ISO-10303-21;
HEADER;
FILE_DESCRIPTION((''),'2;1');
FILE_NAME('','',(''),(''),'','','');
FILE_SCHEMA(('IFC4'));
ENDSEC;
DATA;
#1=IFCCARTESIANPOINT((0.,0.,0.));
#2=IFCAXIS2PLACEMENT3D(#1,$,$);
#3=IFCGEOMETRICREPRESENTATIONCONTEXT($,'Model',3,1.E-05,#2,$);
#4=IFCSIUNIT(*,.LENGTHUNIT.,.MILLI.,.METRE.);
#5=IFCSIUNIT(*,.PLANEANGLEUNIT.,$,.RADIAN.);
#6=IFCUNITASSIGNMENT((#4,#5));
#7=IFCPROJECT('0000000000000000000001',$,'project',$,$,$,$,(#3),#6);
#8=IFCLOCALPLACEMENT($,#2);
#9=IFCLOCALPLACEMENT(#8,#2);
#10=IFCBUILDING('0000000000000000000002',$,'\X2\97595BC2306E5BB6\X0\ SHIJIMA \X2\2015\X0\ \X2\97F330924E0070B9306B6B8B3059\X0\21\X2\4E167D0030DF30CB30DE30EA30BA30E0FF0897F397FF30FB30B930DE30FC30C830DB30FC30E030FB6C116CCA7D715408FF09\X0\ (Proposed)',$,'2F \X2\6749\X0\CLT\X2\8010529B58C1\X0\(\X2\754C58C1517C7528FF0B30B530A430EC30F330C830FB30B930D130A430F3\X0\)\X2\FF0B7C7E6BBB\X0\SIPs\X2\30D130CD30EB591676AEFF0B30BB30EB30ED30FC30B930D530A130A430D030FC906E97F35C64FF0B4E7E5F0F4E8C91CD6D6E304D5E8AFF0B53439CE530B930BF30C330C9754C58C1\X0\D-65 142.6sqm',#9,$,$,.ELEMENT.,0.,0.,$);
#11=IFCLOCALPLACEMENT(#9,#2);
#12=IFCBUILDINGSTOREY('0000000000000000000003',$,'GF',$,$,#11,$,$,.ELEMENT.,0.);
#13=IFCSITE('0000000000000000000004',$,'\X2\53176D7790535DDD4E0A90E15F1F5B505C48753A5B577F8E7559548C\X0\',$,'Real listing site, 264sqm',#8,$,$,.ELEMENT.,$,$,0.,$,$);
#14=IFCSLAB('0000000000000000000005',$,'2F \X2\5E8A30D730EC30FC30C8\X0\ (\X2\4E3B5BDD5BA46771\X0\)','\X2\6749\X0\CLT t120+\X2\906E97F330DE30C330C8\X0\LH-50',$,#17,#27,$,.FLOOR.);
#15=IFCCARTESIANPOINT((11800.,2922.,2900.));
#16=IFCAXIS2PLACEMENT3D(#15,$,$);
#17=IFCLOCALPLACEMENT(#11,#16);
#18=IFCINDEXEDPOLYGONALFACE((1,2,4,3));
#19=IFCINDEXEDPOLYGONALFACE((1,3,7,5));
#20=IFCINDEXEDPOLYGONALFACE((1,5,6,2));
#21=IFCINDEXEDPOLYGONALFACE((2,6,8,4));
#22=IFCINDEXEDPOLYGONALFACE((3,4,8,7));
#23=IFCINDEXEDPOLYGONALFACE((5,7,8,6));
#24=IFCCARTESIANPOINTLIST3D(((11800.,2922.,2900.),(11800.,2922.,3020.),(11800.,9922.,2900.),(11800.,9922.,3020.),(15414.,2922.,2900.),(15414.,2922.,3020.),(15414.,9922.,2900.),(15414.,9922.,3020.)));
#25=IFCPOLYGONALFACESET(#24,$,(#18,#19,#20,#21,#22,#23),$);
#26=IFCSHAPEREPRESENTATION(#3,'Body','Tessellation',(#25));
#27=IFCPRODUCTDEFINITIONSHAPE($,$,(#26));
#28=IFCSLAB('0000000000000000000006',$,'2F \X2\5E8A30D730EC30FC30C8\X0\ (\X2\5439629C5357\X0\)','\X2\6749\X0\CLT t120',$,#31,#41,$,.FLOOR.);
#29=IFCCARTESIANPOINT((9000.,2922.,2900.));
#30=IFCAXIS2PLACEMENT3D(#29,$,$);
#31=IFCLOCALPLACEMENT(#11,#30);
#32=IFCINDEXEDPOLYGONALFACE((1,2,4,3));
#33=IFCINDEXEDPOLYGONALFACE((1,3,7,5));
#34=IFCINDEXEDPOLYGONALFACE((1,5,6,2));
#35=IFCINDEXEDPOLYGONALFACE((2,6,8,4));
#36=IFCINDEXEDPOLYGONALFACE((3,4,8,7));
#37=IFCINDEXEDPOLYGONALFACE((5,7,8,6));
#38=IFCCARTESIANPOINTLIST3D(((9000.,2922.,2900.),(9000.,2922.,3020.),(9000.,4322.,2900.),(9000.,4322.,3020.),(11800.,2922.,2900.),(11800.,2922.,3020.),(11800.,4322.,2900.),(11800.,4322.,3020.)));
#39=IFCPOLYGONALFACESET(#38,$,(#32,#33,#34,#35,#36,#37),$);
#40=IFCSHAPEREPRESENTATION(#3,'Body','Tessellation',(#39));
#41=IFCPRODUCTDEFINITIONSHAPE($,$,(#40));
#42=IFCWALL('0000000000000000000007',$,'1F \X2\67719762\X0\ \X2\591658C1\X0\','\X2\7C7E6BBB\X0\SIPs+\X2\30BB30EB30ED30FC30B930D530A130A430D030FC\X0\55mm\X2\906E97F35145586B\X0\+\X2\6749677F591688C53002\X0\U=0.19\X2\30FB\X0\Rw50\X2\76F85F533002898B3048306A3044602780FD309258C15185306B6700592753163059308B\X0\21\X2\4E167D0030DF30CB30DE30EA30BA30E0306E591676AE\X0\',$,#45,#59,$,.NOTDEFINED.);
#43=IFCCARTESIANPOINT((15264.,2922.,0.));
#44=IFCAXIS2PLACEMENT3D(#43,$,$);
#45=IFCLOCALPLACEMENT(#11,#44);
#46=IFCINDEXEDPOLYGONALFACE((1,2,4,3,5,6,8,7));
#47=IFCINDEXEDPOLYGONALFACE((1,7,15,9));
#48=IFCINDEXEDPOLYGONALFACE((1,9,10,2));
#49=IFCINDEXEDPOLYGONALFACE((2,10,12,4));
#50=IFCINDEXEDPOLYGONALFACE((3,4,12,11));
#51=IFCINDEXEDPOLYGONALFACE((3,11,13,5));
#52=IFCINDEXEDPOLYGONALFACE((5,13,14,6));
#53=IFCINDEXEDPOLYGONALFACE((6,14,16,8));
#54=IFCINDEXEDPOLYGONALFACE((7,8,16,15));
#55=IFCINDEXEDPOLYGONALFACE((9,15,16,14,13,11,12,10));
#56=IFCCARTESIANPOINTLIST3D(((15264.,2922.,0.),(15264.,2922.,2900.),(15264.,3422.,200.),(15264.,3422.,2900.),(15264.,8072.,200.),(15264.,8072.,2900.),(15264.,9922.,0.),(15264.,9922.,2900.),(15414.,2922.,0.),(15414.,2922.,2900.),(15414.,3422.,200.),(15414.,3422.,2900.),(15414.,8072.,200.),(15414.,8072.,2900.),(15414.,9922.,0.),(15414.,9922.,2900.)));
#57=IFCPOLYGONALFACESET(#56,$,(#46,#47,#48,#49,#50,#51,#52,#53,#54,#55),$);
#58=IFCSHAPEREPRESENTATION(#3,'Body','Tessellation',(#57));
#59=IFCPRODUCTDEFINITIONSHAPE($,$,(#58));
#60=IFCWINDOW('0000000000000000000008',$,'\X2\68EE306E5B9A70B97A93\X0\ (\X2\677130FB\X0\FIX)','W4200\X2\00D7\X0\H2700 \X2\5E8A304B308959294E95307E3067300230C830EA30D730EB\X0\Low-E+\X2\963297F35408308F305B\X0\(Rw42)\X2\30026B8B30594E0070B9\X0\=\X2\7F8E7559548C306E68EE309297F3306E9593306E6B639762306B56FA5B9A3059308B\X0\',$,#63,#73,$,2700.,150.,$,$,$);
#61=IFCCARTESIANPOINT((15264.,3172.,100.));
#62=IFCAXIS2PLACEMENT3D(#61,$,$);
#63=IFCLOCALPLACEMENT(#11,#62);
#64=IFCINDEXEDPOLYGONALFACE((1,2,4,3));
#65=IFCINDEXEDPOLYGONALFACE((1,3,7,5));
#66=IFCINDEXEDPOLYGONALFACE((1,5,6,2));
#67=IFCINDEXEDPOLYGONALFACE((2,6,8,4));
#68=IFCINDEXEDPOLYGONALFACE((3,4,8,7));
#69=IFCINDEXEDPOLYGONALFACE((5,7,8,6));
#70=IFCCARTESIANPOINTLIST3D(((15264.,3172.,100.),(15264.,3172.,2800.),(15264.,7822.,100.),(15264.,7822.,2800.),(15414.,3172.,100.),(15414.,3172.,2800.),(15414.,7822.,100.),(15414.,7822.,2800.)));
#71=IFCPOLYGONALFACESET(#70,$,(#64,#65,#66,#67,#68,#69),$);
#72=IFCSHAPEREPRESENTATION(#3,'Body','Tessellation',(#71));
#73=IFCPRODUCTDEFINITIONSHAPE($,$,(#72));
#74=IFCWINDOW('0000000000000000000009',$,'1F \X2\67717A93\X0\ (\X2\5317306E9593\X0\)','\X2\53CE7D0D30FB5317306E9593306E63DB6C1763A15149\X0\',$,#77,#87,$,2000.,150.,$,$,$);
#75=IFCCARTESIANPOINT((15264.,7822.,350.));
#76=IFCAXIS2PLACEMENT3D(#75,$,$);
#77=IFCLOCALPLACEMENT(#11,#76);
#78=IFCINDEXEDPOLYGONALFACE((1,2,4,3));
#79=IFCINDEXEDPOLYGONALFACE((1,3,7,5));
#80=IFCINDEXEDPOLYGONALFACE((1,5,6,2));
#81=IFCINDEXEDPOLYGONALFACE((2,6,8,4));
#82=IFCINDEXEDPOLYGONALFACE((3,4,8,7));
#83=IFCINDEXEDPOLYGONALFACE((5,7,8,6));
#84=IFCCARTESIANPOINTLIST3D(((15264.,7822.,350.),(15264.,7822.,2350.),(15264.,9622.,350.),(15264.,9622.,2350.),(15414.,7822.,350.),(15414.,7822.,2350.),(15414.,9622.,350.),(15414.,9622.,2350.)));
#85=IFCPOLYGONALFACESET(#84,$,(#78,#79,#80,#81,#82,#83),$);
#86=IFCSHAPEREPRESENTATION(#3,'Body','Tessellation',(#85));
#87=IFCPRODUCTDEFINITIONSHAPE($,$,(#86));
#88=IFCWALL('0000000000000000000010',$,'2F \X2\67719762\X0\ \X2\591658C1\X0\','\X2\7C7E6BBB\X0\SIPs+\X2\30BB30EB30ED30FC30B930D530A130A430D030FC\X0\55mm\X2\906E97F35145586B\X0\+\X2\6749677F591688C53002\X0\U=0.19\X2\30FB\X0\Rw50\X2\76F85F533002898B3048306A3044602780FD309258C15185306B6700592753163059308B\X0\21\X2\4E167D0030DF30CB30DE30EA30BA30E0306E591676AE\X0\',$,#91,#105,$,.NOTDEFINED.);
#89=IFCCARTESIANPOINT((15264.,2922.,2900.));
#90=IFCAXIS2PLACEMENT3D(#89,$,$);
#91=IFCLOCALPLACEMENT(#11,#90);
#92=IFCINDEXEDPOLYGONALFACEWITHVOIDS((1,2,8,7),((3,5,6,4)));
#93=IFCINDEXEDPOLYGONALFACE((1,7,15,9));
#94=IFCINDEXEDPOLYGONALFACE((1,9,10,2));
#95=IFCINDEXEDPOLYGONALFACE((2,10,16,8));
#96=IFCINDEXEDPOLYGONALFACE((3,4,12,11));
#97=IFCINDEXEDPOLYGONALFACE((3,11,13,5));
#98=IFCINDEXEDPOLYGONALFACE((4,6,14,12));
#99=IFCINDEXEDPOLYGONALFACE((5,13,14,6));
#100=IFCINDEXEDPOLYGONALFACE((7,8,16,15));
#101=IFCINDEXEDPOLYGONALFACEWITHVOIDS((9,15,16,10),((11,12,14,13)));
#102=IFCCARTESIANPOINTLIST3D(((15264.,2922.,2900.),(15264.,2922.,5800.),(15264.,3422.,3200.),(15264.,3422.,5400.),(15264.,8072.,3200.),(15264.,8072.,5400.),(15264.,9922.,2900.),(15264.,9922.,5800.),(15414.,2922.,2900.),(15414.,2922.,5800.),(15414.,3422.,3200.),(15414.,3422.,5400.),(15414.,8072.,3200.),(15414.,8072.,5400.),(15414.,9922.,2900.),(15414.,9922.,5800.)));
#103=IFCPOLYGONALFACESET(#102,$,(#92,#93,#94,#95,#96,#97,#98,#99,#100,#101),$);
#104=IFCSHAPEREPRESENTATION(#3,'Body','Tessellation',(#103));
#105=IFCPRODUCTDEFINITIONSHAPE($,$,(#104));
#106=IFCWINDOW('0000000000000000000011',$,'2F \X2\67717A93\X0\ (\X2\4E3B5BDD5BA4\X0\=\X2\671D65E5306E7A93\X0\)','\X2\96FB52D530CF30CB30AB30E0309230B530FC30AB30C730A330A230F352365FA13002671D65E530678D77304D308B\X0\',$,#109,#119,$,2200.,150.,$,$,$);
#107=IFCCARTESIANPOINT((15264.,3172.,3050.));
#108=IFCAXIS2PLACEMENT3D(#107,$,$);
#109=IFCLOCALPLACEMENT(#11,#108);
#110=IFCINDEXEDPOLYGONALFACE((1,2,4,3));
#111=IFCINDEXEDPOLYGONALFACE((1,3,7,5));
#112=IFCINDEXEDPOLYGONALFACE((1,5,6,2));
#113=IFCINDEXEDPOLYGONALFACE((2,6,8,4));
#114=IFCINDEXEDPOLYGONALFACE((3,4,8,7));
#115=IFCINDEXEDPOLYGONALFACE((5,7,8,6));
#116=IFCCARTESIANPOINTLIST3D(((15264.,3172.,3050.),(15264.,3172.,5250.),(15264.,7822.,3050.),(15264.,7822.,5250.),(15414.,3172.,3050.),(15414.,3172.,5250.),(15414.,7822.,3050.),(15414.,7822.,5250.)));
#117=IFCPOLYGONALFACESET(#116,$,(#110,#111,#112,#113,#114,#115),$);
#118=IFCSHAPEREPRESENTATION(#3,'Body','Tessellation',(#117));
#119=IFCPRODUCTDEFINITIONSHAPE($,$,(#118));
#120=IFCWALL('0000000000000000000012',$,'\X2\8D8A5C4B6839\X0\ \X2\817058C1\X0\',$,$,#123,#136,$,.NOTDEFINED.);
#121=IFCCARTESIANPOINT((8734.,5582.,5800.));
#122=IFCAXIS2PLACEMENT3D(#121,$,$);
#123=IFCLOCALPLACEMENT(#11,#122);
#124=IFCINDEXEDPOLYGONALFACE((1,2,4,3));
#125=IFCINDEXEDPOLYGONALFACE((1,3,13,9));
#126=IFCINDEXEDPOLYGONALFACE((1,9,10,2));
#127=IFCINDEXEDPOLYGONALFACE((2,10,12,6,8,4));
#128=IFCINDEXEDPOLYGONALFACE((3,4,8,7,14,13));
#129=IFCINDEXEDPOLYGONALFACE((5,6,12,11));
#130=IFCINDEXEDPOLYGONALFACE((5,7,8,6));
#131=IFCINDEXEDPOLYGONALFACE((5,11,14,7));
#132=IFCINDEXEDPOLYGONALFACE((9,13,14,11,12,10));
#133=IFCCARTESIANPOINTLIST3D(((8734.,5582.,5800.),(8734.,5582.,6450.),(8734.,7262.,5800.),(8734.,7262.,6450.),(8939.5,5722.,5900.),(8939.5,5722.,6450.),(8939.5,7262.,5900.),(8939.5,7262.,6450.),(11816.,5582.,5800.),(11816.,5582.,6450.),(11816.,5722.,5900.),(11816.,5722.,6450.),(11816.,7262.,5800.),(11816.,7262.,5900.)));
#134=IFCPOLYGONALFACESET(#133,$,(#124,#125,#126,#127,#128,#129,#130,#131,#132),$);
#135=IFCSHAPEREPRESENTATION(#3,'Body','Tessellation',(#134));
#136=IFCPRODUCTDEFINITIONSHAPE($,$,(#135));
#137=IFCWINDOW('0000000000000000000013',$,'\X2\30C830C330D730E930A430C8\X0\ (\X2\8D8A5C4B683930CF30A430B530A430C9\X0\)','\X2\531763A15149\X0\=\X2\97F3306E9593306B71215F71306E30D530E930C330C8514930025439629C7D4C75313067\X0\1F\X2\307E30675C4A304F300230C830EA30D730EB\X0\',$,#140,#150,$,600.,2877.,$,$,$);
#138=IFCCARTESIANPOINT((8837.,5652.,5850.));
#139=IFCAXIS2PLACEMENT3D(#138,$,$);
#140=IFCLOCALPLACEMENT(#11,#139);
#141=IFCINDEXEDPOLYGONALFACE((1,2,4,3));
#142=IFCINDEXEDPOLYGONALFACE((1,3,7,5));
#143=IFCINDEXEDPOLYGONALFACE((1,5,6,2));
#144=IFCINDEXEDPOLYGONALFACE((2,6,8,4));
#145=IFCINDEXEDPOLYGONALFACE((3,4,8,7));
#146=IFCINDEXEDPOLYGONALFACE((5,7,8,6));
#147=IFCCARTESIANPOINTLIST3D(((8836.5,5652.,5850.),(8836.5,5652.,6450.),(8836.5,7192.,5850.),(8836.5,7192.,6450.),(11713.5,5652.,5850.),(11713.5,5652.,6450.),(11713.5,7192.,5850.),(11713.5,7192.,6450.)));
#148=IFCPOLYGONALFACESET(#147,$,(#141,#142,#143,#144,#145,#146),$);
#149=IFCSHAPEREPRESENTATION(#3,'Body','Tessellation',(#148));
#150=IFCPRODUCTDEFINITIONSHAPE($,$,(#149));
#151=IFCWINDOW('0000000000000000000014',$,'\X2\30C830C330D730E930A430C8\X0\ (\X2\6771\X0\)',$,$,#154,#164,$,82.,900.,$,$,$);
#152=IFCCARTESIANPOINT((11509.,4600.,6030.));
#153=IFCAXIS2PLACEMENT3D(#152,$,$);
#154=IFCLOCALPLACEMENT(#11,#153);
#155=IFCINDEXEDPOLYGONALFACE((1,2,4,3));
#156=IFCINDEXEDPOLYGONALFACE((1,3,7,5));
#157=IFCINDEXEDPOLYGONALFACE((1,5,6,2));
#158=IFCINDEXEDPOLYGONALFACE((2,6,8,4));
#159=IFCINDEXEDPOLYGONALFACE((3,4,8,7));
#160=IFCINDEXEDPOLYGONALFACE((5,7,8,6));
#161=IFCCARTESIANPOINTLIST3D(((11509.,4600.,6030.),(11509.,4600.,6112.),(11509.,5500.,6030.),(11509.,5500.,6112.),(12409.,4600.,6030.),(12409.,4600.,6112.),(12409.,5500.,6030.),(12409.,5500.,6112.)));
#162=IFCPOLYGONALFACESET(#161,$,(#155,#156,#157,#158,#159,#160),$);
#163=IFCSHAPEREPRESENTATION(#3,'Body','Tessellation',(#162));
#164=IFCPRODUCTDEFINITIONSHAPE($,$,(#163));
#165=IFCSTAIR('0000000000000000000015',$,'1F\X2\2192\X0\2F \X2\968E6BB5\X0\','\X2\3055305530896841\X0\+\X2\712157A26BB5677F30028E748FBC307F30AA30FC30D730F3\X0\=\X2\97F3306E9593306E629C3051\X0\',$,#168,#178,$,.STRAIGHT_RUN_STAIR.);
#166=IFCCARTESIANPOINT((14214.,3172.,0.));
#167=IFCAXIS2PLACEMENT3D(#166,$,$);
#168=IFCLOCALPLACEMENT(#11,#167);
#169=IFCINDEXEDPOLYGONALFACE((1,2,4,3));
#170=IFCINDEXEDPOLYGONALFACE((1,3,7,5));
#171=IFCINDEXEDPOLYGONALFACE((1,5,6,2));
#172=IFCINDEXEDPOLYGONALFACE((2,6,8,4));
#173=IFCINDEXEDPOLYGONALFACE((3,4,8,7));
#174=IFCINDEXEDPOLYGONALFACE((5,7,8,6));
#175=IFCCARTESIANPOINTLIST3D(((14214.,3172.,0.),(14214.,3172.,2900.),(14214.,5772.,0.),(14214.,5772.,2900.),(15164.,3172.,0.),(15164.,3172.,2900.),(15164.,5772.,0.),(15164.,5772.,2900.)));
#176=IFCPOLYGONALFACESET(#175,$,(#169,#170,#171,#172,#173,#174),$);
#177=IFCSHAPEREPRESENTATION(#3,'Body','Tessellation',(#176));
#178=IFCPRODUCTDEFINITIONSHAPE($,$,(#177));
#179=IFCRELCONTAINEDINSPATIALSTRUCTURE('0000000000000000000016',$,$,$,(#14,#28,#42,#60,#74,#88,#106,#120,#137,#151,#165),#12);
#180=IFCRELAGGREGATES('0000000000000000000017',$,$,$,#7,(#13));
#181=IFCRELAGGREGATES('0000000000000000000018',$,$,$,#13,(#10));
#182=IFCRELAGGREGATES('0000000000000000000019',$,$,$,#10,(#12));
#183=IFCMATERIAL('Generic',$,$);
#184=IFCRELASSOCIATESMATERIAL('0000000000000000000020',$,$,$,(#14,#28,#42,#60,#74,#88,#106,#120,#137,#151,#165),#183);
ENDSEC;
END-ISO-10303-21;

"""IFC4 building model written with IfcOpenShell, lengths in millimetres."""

from ifc_helpers import new_model, si_unit, frame, frame_2d, origin, place, context, project, spatial, rectangle, extrude, material, element, fill, save


model = new_model("IFC4")

# Units and contexts
model_context = context("Model", 3, precision=1e-05, world=origin())
ifc_project = project(units=[si_unit("LENGTHUNIT", "METRE", prefix="MILLI"), si_unit("PLANEANGLEUNIT", "RADIAN")], contexts=[model_context])

# Site, building, storey
site_placement = place(None, origin())
site = spatial("IfcSite", under=ifc_project, at=site_placement, Name="北海道川上郡弟子屈町字美留和", ObjectType="Real listing site, 264sqm", CompositionType="ELEMENT", RefElevation=0.0)
building_placement = place(site_placement, origin())
building = spatial("IfcBuilding", under=site, at=building_placement, Name="静寂の家 SHIJIMA ― 音を一点に残す21世紀ミニマリズム（音響・スマートホーム・民泊統合） (Proposed)", ObjectType="2F 杉CLT耐力壁(界壁兼用＋サイレント・スパイン)＋籾殻SIPsパネル外皮＋セルロースファイバー遮音層＋乾式二重浮き床＋千鳥スタッド界壁D-65 142.6sqm", CompositionType="ELEMENT", ElevationOfRefHeight=0.0, ElevationOfTerrain=0.0)
storey_placement = place(building_placement, origin())
storey = spatial("IfcBuildingStorey", under=building, at=storey_placement, Name="GF", CompositionType="ELEMENT", Elevation=0.0)

# Slabs
ifc_material = material(Name="Generic")
slab_1_placement = place(storey_placement, frame((11800.0, 2922.0, 2900.0)))
element("IfcSlab", 1, at=slab_1_placement, inside=storey, material=ifc_material, Name="2F 床プレート (主寝室東)", Description="杉CLT t120+遮音マットLH-50", PredefinedType="FLOOR", context=model_context, shape_type="SweptSolid", body=[
    extrude(rectangle(XDim=3614.0, YDim=7000.0, at=frame_2d((1807.0, 3500.0))), frame((11800.0, 2922.0, 2900.0)), (0.0, 0.0, 1.0), 120.0),
])
slab_2_placement = place(storey_placement, frame((9000.0, 2922.0, 2900.0)))
element("IfcSlab", 2, at=slab_2_placement, inside=storey, material=ifc_material, Name="2F 床プレート (吹抜南)", Description="杉CLT t120", PredefinedType="FLOOR", context=model_context, shape_type="SweptSolid", body=[
    extrude(rectangle(XDim=2800.0, YDim=1400.0, at=frame_2d((1400.0, 700.0))), frame((9000.0, 2922.0, 2900.0)), (0.0, 0.0, 1.0), 120.0),
])

# Wall, openings, windows
wall_1_placement = place(storey_placement, frame((15264.0, 2922.0, 0.0)))
wall_1 = element("IfcWall", 3, at=wall_1_placement, inside=storey, material=ifc_material, Name="1F 東面 外壁", Description="籾殻SIPs+セルロースファイバー55mm遮音充填+杉板外装。U=0.19・Rw50相当。見えない性能を壁内に最大化する21世紀ミニマリズムの外皮", PredefinedType="NOTDEFINED", context=model_context, shape_type="SweptSolid", body=[
    extrude(rectangle(XDim=150.0, YDim=7000.0, at=frame_2d((75.0, 3500.0))), frame((15264.0, 2922.0, 0.0)), (0.0, 0.0, 1.0), 2900.0),
])
opening_1_placement = place(storey_placement, frame((15264.0, 3172.0, 100.0)))
opening_1 = element("IfcOpeningElement", 4, at=opening_1_placement, cuts=wall_1, PredefinedType="NOTDEFINED", context=model_context, shape_type="SweptSolid", body=[
    extrude(rectangle(XDim=150.0, YDim=4650.0, at=frame_2d((75.0, 2325.0))), frame((15264.0, 3172.0, 100.0)), (0.0, 0.0, 1.0), 2700.0),
])
opening_2_placement = place(storey_placement, frame((15264.0, 7822.0, 350.0)))
opening_2 = element("IfcOpeningElement", 5, at=opening_2_placement, cuts=wall_1, PredefinedType="NOTDEFINED", context=model_context, shape_type="SweptSolid", body=[
    extrude(rectangle(XDim=150.0, YDim=1800.0, at=frame_2d((75.0, 900.0))), frame((15264.0, 7822.0, 350.0)), (0.0, 0.0, 1.0), 2000.0),
])
window_1_placement = place(storey_placement, frame((15264.0, 3172.0, 100.0)))
window_1 = element("IfcWindow", 6, at=window_1_placement, inside=storey, material=ifc_material, Name="森の定点窓 (東・FIX)", Description="W4200×H2700 床から天井まで。トリプルLow-E+防音合わせ(Rw42)。残す一点=美留和の森を音の間の正面に固定する", OverallHeight=2700.0, OverallWidth=150.0, context=model_context, shape_type="SweptSolid", body=[
    extrude(rectangle(XDim=150.0, YDim=4650.0, at=frame_2d((75.0, 2325.0))), frame((15264.0, 3172.0, 100.0)), (0.0, 0.0, 1.0), 2700.0),
])
fill(opening_1, window_1)
window_2_placement = place(storey_placement, frame((15264.0, 7822.0, 350.0)))
window_2 = element("IfcWindow", 7, at=window_2_placement, inside=storey, material=ifc_material, Name="1F 東窓 (北の間)", Description="収納・北の間の換気採光", OverallHeight=2000.0, OverallWidth=150.0, context=model_context, shape_type="SweptSolid", body=[
    extrude(rectangle(XDim=150.0, YDim=1800.0, at=frame_2d((75.0, 900.0))), frame((15264.0, 7822.0, 350.0)), (0.0, 0.0, 1.0), 2000.0),
])
fill(opening_2, window_2)

# Walls, openings, windows
wall_2_placement = place(storey_placement, frame((15264.0, 2922.0, 2900.0)))
wall_2 = element("IfcWall", 8, at=wall_2_placement, inside=storey, material=ifc_material, Name="2F 東面 外壁", Description="籾殻SIPs+セルロースファイバー55mm遮音充填+杉板外装。U=0.19・Rw50相当。見えない性能を壁内に最大化する21世紀ミニマリズムの外皮", PredefinedType="NOTDEFINED", context=model_context, shape_type="SweptSolid", body=[
    extrude(rectangle(XDim=150.0, YDim=7000.0, at=frame_2d((75.0, 3500.0))), frame((15264.0, 2922.0, 2900.0)), (0.0, 0.0, 1.0), 2900.0),
])
opening_3_placement = place(storey_placement, frame((15264.0, 3172.0, 3050.0)))
opening_3 = element("IfcOpeningElement", 9, at=opening_3_placement, cuts=wall_2, PredefinedType="NOTDEFINED", context=model_context, shape_type="SweptSolid", body=[
    extrude(rectangle(XDim=150.0, YDim=4650.0, at=frame_2d((75.0, 2325.0))), frame((15264.0, 3172.0, 3050.0)), (0.0, 0.0, 1.0), 2200.0),
])
window_3_placement = place(storey_placement, frame((15264.0, 3172.0, 3050.0)))
window_3 = element("IfcWindow", 10, at=window_3_placement, inside=storey, material=ifc_material, Name="2F 東窓 (主寝室=朝日の窓)", Description="電動ハニカムをサーカディアン制御。朝日で起きる", OverallHeight=2200.0, OverallWidth=150.0, context=model_context, shape_type="SweptSolid", body=[
    extrude(rectangle(XDim=150.0, YDim=4650.0, at=frame_2d((75.0, 2325.0))), frame((15264.0, 3172.0, 3050.0)), (0.0, 0.0, 1.0), 2200.0),
])
fill(opening_3, window_3)
wall_3_placement = place(storey_placement, frame((8734.0, 5582.0, 5800.0)))
wall_3 = element("IfcWall", 11, at=wall_3_placement, inside=storey, material=ifc_material, Name="越屋根 腰壁", PredefinedType="NOTDEFINED", context=model_context, shape_type="SweptSolid", body=[
    extrude(rectangle(XDim=3082.0, YDim=1680.0, at=frame_2d((1541.0, 840.0))), frame((8734.0, 5582.0, 5800.0)), (0.0, 0.0, 1.0), 650.0),
])
opening_4_placement = place(storey_placement, frame((8837.0, 5652.0, 5850.0)))
opening_4 = element("IfcOpeningElement", 12, at=opening_4_placement, cuts=wall_3, PredefinedType="NOTDEFINED", context=model_context, shape_type="SweptSolid", body=[
    extrude(rectangle(XDim=2877.0, YDim=1540.0, at=frame_2d((1438.0, 770.0))), frame((8837.0, 5652.0, 5850.0)), (0.0, 0.0, 1.0), 600.0),
])
window_4_placement = place(storey_placement, frame((8837.0, 5652.0, 5850.0)))
window_4 = element("IfcWindow", 13, at=window_4_placement, inside=storey, material=ifc_material, Name="トップライト (越屋根ハイサイド)", Description="北採光=音の間に無影のフラット光。吹抜経由で1Fまで届く。トリプル", OverallHeight=600.0, OverallWidth=2877.0, context=model_context, shape_type="SweptSolid", body=[
    extrude(rectangle(XDim=2877.0, YDim=1540.0, at=frame_2d((1438.0, 770.0))), frame((8837.0, 5652.0, 5850.0)), (0.0, 0.0, 1.0), 600.0),
])
fill(opening_4, window_4)

# Window
window_5_placement = place(storey_placement, frame((11509.0, 4600.0, 6030.0)))
element("IfcWindow", 14, at=window_5_placement, inside=storey, material=ifc_material, Name="トップライト (東)", OverallHeight=82.0, OverallWidth=900.0, context=model_context, shape_type="SweptSolid", body=[
    extrude(rectangle(XDim=900.0, YDim=900.0, at=frame_2d((450.0, 450.0))), frame((11509.0, 4600.0, 6030.0)), (0.0, 0.0, 1.0), 82.0),
])

# Stair
stair_placement = place(storey_placement, frame((14214.0, 3172.0, 0.0)))
element("IfcStair", 15, at=stair_placement, inside=storey, material=ifc_material, Name="1F→2F 階段", Description="ささら桁+無垢段板。蹴込みオープン=音の間の抜け", PredefinedType="STRAIGHT_RUN_STAIR", context=model_context, shape_type="SweptSolid", body=[
    extrude(rectangle(XDim=950.0, YDim=2600.0, at=frame_2d((475.0, 1300.0))), frame((14214.0, 3172.0, 0.0)), (0.0, 0.0, 1.0), 2900.0),
])

save(model, "model.ifc")
